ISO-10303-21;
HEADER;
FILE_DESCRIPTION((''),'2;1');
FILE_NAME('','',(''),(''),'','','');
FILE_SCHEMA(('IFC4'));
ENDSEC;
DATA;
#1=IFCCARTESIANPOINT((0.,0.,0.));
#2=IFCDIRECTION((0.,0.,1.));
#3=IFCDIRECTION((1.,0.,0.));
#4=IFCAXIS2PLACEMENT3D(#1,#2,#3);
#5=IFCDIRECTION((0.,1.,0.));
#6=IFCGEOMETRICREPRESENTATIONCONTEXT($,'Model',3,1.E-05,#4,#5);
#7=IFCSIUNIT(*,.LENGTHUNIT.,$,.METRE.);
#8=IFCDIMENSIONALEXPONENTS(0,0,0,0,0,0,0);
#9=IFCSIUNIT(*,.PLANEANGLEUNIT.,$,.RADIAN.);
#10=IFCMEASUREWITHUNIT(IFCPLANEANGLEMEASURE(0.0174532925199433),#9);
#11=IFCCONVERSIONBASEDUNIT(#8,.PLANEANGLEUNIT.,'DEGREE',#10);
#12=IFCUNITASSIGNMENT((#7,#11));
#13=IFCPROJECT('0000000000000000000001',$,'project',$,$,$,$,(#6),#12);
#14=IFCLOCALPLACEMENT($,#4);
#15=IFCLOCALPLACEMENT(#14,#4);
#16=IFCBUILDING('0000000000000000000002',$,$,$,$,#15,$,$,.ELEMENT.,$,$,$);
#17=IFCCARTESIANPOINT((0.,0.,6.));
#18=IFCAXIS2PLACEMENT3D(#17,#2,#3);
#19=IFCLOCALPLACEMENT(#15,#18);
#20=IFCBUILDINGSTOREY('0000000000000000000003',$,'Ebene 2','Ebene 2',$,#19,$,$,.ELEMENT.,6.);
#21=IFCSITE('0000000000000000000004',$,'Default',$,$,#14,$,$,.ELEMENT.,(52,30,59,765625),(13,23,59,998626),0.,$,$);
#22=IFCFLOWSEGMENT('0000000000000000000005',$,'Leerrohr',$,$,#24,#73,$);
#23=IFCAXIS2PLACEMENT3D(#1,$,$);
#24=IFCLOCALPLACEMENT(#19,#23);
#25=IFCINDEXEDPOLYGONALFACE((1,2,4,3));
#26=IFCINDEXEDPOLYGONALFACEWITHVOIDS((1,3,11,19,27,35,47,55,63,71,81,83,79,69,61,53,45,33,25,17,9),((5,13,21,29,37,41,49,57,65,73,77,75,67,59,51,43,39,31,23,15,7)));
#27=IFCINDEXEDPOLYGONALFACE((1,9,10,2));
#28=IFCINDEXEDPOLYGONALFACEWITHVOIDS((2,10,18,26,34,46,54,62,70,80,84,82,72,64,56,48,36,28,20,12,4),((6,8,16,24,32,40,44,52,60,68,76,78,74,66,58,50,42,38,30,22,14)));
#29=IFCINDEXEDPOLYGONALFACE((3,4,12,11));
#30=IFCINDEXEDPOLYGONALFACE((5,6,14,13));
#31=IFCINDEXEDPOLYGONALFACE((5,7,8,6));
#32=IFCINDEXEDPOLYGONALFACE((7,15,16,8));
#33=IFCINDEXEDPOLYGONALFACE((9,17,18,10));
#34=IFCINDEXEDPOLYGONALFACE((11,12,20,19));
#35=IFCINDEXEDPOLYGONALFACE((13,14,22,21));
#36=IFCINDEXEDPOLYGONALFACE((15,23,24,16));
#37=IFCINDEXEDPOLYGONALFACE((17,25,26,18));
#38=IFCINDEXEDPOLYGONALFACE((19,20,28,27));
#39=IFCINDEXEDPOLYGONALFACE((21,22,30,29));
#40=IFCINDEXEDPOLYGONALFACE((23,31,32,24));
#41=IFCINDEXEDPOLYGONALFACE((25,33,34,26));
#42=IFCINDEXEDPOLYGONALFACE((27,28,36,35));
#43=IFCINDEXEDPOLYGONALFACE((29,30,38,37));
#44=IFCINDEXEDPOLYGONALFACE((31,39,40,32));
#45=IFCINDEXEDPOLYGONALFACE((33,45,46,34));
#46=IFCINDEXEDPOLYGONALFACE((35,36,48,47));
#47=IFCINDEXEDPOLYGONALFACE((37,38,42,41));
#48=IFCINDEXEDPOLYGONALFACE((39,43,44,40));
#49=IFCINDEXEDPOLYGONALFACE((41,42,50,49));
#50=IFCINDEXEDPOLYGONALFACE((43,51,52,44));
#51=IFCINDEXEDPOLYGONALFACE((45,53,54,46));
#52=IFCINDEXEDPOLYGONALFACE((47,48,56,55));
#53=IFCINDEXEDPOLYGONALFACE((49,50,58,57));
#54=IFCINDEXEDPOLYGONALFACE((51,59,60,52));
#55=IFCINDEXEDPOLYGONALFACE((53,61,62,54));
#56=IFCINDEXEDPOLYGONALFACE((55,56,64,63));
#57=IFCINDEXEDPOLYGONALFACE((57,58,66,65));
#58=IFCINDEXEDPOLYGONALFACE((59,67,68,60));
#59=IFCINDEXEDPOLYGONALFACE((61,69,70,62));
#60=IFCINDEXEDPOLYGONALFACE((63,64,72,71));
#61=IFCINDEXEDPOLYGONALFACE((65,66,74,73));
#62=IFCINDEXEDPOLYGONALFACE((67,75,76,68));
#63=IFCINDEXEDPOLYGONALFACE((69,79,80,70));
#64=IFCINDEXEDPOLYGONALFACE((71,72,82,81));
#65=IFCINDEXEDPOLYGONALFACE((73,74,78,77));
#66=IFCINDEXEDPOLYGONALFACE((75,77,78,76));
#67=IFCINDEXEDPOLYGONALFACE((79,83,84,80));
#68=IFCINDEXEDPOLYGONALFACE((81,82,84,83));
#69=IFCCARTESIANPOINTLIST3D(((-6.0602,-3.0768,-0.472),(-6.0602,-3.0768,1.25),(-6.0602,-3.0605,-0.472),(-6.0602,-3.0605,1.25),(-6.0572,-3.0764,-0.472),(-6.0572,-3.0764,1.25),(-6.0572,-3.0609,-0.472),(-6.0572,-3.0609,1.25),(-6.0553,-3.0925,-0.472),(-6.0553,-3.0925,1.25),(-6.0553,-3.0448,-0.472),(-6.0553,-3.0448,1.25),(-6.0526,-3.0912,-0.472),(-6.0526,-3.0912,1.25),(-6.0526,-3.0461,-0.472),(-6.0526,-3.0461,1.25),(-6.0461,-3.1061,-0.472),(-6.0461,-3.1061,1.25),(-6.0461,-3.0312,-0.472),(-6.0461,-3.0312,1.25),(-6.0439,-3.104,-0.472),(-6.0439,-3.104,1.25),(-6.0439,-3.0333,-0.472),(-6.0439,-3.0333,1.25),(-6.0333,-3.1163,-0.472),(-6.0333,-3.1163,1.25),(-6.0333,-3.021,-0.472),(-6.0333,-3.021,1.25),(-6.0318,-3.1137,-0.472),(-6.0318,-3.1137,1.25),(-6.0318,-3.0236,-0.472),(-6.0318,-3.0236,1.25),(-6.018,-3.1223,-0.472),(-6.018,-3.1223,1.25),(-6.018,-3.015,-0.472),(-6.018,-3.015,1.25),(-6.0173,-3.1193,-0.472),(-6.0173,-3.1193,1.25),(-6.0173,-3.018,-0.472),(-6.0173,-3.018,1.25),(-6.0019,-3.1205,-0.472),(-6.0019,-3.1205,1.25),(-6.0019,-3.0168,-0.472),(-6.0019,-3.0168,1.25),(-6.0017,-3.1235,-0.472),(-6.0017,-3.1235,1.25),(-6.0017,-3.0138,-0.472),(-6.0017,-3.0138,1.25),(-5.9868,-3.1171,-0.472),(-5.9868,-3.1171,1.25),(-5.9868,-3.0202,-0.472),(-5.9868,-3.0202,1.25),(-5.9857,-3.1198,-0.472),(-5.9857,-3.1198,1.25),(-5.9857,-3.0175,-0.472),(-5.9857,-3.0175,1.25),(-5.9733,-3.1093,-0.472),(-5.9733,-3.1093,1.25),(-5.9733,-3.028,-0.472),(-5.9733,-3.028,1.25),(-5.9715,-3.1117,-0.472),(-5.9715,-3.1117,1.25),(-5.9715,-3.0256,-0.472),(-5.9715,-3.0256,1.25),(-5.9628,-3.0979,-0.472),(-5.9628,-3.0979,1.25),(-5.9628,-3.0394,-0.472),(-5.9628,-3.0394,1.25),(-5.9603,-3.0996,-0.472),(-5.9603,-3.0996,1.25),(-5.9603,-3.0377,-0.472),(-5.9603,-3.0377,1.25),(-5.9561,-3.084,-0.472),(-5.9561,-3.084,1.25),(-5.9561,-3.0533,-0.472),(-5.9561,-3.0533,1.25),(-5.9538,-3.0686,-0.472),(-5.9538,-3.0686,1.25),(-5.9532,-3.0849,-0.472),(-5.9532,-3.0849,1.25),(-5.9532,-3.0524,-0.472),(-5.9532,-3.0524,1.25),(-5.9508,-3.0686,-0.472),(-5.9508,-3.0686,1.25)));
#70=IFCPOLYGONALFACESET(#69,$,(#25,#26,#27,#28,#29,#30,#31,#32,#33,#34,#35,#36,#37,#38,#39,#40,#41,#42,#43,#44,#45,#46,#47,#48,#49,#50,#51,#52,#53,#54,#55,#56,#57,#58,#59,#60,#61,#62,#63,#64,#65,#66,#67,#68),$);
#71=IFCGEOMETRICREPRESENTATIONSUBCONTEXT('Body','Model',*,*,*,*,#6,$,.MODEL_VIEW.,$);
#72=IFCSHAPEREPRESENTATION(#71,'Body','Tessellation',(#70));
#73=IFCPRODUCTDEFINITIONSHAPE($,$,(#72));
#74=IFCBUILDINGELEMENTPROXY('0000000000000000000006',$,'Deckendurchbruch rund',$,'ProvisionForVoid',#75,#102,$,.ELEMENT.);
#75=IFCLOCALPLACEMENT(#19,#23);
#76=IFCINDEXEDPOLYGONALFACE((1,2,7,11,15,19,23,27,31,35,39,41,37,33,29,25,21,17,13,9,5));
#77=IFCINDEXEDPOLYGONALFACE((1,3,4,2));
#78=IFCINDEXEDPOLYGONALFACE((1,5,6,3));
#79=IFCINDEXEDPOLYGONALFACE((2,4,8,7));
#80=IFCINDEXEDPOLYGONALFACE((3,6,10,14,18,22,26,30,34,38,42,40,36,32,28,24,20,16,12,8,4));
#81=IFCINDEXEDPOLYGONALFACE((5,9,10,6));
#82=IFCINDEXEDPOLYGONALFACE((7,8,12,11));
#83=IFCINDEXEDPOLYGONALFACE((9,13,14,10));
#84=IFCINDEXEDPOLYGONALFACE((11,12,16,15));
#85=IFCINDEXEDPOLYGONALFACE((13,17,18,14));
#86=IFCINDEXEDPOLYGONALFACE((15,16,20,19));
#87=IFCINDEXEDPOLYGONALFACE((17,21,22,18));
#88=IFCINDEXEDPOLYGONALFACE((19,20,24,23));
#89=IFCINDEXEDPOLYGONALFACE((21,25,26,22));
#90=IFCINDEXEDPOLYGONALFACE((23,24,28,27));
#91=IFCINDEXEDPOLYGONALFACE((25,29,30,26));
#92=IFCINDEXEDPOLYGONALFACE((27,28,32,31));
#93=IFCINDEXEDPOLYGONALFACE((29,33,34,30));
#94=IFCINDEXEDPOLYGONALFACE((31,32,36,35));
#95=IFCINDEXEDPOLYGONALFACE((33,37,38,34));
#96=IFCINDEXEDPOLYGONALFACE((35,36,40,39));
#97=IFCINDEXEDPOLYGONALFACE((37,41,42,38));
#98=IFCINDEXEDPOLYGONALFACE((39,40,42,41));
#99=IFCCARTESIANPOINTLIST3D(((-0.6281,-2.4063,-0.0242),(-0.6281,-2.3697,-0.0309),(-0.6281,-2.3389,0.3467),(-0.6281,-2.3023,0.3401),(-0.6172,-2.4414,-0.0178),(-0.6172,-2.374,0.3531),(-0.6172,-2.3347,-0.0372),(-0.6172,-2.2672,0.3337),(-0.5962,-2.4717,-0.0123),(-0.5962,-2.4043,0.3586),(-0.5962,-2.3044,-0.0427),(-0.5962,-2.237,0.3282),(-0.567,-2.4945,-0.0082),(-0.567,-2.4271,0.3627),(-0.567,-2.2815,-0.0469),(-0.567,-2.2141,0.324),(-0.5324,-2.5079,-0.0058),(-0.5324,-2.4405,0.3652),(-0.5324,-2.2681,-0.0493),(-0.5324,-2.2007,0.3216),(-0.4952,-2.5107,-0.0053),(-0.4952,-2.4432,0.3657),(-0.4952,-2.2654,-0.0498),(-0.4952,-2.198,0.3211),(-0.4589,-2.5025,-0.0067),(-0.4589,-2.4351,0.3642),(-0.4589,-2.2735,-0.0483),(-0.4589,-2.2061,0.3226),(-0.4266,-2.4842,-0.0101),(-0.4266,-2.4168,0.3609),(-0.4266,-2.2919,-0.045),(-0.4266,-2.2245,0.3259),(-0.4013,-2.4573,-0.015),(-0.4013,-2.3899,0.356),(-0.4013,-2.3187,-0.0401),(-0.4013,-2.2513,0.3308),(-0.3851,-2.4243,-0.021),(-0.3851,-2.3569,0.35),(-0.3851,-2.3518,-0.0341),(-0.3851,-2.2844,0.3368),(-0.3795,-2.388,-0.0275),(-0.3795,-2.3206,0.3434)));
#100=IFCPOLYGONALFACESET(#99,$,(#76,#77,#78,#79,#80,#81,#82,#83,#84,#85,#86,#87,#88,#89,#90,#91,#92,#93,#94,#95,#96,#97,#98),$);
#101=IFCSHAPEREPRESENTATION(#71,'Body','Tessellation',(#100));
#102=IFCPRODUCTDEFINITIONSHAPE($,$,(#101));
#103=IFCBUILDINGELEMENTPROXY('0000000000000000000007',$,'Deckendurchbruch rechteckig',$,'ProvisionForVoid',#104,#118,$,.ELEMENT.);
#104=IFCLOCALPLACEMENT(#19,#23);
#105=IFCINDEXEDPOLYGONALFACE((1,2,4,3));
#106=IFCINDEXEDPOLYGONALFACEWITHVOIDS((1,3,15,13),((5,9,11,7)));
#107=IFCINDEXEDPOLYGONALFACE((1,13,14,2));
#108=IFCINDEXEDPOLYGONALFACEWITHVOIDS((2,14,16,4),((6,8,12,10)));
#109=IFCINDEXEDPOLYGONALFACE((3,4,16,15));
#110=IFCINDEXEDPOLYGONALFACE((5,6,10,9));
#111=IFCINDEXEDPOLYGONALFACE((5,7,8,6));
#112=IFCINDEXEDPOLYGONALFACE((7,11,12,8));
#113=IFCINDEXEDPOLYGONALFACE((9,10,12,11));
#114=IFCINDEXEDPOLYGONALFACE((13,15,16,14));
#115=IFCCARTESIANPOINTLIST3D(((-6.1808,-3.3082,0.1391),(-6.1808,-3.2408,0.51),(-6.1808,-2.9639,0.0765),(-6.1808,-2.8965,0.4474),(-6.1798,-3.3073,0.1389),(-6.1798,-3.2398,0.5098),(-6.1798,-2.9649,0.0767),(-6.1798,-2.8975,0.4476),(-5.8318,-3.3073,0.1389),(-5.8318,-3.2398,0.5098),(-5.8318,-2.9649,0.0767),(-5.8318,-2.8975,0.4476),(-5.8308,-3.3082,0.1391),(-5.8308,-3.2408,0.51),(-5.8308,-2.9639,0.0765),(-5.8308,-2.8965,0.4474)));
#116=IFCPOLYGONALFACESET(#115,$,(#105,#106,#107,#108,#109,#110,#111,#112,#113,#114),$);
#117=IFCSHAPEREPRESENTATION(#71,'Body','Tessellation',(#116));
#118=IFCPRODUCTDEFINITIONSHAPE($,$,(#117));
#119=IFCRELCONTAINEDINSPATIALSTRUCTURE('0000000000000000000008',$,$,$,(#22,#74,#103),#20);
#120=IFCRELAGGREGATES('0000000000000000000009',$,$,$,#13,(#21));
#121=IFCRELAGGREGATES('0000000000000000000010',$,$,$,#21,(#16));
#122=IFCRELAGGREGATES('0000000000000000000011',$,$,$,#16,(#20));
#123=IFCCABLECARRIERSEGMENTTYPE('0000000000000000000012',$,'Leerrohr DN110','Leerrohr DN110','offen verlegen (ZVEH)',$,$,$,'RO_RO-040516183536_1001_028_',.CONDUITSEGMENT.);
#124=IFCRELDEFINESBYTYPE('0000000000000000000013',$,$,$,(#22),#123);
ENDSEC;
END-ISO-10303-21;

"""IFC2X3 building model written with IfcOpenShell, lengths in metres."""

from ifc_helpers import new_model, entity, si_unit, converted_unit, direction, frame, origin_with_axes, origin_2d_with_axis, place, context, subcontext, project, spatial, hollow_rectangle, circle, hollow_circle, extrude, source, transform, mapped, type_object, element, save


model = new_model("IFC2X3")

# Units and contexts
model_context = context("Model", 3, precision=1e-05, world=origin_with_axes(), true_north=direction((0.0, 1.0, 0.0)))
body_context = subcontext(model_context, "Body", "Model", "MODEL_VIEW")
ifc_project = project(units=[si_unit("LENGTHUNIT", "METRE"), converted_unit("PLANEANGLEUNIT", "DEGREE", entity("IfcPlaneAngleMeasure", 0.0174532925199433), si_unit("PLANEANGLEUNIT", "RADIAN"), dimensions=[0, 0, 0, 0, 0, 0, 0])], contexts=[model_context])

# Site, building, storey
site_placement = place(None, origin_with_axes())
site = spatial("IfcSite", under=ifc_project, at=site_placement, Name="Default", CompositionType="ELEMENT", RefLatitude=(52, 30, 59, 765625), RefLongitude=(13, 23, 59, 998626), RefElevation=0.0)
building_placement = place(site_placement, origin_with_axes())
building = spatial("IfcBuilding", under=site, at=building_placement, CompositionType="ELEMENT")
storey_placement = place(building_placement, frame((0.0, 0.0, 6.0), z_axis=(0.0, 0.0, 1.0), x_axis=(1.0, 0.0, 0.0)))
storey = spatial("IfcBuildingStorey", under=building, at=storey_placement, Name="Ebene 2", Description="Ebene 2", CompositionType="ELEMENT", Elevation=6.0)

# Flow segment
cable_carrier_segment_type = type_object("IfcCableCarrierSegmentType", Name="Leerrohr DN110", Description="Leerrohr DN110", ApplicableOccurrence="offen verlegen (ZVEH)", ElementType="RO_RO-040516183536_1001_028_", PredefinedType="CONDUITSEGMENT")
flow_segment_placement = place(storey_placement, frame((-6.0058, -3.0686, -0.472), z_axis=(-1.0, 0.0, 0.0), x_axis=(0.0, 0.0, 1.0)))
element("IfcFlowSegment", 1, at=flow_segment_placement, inside=storey, type_object=cable_carrier_segment_type, Name="Leerrohr", context=body_context, shape_type="SweptSolid", body=[
    extrude(hollow_circle(Radius=0.055, WallThickness=0.003, at=origin_2d_with_axis()), frame((0.0, 0.0, 0.0), z_axis=(1.0, 0.0, 0.0), x_axis=(0.0, 0.0, -1.0)), (0.0, 0.0, 1.0), 1.722),
])

# Building element proxies
shared_shape_1 = source(origin_with_axes(), body_context, "Body", "SweptSolid", [
    extrude(circle(Radius=0.125, at=origin_2d_with_axis()), frame((0.125, 0.125, 0.0), z_axis=(0.0, 0.0, 1.0), x_axis=(1.0, 0.0, 0.0)), (0.0, 0.0, -1.0), 0.377),
])
proxy_1_placement = place(storey_placement, frame((-0.6295, -2.4436, 0.3657), z_axis=(0.0, 0.178802, 0.983885), x_axis=(1.0, 0.0, 0.0)))
element("IfcBuildingElementProxy", 2, at=proxy_1_placement, inside=storey, Name="Deckendurchbruch rund", ObjectType="ProvisionForVoid", CompositionType="ELEMENT", context=body_context, shape_type="MappedRepresentation", body=[
    mapped(shared_shape_1, transform((0.0, 0.0, 0.0), x_axis=(1.0, 0.0, 0.0), y_axis=(0.0, 1.0, 0.0), z_axis=(0.0, 0.0, 1.0), scale=1.0)),
])
shared_shape_2 = source(origin_with_axes(), body_context, "Body", "SweptSolid", [
    extrude(hollow_rectangle(XDim=0.35, YDim=0.35, WallThickness=0.001, at=origin_2d_with_axis()), frame((0.175, 0.175, -0.377), z_axis=(0.0, 0.0, 1.0), x_axis=(1.0, 0.0, 0.0)), (0.0, 0.0, 1.0), 0.377),
])
proxy_2_placement = place(storey_placement, frame((-6.1808, -3.2408, 0.51), z_axis=(0.0, 0.178802, 0.983885), x_axis=(1.0, 0.0, 0.0)))
element("IfcBuildingElementProxy", 3, at=proxy_2_placement, inside=storey, Name="Deckendurchbruch rechteckig", ObjectType="ProvisionForVoid", CompositionType="ELEMENT", context=body_context, shape_type="MappedRepresentation", body=[
    mapped(shared_shape_2, transform((0.0, 0.0, 0.0), x_axis=(1.0, 0.0, 0.0), y_axis=(0.0, 1.0, 0.0), z_axis=(0.0, 0.0, 1.0), scale=1.0)),
])

save(model, "model.ifc")
